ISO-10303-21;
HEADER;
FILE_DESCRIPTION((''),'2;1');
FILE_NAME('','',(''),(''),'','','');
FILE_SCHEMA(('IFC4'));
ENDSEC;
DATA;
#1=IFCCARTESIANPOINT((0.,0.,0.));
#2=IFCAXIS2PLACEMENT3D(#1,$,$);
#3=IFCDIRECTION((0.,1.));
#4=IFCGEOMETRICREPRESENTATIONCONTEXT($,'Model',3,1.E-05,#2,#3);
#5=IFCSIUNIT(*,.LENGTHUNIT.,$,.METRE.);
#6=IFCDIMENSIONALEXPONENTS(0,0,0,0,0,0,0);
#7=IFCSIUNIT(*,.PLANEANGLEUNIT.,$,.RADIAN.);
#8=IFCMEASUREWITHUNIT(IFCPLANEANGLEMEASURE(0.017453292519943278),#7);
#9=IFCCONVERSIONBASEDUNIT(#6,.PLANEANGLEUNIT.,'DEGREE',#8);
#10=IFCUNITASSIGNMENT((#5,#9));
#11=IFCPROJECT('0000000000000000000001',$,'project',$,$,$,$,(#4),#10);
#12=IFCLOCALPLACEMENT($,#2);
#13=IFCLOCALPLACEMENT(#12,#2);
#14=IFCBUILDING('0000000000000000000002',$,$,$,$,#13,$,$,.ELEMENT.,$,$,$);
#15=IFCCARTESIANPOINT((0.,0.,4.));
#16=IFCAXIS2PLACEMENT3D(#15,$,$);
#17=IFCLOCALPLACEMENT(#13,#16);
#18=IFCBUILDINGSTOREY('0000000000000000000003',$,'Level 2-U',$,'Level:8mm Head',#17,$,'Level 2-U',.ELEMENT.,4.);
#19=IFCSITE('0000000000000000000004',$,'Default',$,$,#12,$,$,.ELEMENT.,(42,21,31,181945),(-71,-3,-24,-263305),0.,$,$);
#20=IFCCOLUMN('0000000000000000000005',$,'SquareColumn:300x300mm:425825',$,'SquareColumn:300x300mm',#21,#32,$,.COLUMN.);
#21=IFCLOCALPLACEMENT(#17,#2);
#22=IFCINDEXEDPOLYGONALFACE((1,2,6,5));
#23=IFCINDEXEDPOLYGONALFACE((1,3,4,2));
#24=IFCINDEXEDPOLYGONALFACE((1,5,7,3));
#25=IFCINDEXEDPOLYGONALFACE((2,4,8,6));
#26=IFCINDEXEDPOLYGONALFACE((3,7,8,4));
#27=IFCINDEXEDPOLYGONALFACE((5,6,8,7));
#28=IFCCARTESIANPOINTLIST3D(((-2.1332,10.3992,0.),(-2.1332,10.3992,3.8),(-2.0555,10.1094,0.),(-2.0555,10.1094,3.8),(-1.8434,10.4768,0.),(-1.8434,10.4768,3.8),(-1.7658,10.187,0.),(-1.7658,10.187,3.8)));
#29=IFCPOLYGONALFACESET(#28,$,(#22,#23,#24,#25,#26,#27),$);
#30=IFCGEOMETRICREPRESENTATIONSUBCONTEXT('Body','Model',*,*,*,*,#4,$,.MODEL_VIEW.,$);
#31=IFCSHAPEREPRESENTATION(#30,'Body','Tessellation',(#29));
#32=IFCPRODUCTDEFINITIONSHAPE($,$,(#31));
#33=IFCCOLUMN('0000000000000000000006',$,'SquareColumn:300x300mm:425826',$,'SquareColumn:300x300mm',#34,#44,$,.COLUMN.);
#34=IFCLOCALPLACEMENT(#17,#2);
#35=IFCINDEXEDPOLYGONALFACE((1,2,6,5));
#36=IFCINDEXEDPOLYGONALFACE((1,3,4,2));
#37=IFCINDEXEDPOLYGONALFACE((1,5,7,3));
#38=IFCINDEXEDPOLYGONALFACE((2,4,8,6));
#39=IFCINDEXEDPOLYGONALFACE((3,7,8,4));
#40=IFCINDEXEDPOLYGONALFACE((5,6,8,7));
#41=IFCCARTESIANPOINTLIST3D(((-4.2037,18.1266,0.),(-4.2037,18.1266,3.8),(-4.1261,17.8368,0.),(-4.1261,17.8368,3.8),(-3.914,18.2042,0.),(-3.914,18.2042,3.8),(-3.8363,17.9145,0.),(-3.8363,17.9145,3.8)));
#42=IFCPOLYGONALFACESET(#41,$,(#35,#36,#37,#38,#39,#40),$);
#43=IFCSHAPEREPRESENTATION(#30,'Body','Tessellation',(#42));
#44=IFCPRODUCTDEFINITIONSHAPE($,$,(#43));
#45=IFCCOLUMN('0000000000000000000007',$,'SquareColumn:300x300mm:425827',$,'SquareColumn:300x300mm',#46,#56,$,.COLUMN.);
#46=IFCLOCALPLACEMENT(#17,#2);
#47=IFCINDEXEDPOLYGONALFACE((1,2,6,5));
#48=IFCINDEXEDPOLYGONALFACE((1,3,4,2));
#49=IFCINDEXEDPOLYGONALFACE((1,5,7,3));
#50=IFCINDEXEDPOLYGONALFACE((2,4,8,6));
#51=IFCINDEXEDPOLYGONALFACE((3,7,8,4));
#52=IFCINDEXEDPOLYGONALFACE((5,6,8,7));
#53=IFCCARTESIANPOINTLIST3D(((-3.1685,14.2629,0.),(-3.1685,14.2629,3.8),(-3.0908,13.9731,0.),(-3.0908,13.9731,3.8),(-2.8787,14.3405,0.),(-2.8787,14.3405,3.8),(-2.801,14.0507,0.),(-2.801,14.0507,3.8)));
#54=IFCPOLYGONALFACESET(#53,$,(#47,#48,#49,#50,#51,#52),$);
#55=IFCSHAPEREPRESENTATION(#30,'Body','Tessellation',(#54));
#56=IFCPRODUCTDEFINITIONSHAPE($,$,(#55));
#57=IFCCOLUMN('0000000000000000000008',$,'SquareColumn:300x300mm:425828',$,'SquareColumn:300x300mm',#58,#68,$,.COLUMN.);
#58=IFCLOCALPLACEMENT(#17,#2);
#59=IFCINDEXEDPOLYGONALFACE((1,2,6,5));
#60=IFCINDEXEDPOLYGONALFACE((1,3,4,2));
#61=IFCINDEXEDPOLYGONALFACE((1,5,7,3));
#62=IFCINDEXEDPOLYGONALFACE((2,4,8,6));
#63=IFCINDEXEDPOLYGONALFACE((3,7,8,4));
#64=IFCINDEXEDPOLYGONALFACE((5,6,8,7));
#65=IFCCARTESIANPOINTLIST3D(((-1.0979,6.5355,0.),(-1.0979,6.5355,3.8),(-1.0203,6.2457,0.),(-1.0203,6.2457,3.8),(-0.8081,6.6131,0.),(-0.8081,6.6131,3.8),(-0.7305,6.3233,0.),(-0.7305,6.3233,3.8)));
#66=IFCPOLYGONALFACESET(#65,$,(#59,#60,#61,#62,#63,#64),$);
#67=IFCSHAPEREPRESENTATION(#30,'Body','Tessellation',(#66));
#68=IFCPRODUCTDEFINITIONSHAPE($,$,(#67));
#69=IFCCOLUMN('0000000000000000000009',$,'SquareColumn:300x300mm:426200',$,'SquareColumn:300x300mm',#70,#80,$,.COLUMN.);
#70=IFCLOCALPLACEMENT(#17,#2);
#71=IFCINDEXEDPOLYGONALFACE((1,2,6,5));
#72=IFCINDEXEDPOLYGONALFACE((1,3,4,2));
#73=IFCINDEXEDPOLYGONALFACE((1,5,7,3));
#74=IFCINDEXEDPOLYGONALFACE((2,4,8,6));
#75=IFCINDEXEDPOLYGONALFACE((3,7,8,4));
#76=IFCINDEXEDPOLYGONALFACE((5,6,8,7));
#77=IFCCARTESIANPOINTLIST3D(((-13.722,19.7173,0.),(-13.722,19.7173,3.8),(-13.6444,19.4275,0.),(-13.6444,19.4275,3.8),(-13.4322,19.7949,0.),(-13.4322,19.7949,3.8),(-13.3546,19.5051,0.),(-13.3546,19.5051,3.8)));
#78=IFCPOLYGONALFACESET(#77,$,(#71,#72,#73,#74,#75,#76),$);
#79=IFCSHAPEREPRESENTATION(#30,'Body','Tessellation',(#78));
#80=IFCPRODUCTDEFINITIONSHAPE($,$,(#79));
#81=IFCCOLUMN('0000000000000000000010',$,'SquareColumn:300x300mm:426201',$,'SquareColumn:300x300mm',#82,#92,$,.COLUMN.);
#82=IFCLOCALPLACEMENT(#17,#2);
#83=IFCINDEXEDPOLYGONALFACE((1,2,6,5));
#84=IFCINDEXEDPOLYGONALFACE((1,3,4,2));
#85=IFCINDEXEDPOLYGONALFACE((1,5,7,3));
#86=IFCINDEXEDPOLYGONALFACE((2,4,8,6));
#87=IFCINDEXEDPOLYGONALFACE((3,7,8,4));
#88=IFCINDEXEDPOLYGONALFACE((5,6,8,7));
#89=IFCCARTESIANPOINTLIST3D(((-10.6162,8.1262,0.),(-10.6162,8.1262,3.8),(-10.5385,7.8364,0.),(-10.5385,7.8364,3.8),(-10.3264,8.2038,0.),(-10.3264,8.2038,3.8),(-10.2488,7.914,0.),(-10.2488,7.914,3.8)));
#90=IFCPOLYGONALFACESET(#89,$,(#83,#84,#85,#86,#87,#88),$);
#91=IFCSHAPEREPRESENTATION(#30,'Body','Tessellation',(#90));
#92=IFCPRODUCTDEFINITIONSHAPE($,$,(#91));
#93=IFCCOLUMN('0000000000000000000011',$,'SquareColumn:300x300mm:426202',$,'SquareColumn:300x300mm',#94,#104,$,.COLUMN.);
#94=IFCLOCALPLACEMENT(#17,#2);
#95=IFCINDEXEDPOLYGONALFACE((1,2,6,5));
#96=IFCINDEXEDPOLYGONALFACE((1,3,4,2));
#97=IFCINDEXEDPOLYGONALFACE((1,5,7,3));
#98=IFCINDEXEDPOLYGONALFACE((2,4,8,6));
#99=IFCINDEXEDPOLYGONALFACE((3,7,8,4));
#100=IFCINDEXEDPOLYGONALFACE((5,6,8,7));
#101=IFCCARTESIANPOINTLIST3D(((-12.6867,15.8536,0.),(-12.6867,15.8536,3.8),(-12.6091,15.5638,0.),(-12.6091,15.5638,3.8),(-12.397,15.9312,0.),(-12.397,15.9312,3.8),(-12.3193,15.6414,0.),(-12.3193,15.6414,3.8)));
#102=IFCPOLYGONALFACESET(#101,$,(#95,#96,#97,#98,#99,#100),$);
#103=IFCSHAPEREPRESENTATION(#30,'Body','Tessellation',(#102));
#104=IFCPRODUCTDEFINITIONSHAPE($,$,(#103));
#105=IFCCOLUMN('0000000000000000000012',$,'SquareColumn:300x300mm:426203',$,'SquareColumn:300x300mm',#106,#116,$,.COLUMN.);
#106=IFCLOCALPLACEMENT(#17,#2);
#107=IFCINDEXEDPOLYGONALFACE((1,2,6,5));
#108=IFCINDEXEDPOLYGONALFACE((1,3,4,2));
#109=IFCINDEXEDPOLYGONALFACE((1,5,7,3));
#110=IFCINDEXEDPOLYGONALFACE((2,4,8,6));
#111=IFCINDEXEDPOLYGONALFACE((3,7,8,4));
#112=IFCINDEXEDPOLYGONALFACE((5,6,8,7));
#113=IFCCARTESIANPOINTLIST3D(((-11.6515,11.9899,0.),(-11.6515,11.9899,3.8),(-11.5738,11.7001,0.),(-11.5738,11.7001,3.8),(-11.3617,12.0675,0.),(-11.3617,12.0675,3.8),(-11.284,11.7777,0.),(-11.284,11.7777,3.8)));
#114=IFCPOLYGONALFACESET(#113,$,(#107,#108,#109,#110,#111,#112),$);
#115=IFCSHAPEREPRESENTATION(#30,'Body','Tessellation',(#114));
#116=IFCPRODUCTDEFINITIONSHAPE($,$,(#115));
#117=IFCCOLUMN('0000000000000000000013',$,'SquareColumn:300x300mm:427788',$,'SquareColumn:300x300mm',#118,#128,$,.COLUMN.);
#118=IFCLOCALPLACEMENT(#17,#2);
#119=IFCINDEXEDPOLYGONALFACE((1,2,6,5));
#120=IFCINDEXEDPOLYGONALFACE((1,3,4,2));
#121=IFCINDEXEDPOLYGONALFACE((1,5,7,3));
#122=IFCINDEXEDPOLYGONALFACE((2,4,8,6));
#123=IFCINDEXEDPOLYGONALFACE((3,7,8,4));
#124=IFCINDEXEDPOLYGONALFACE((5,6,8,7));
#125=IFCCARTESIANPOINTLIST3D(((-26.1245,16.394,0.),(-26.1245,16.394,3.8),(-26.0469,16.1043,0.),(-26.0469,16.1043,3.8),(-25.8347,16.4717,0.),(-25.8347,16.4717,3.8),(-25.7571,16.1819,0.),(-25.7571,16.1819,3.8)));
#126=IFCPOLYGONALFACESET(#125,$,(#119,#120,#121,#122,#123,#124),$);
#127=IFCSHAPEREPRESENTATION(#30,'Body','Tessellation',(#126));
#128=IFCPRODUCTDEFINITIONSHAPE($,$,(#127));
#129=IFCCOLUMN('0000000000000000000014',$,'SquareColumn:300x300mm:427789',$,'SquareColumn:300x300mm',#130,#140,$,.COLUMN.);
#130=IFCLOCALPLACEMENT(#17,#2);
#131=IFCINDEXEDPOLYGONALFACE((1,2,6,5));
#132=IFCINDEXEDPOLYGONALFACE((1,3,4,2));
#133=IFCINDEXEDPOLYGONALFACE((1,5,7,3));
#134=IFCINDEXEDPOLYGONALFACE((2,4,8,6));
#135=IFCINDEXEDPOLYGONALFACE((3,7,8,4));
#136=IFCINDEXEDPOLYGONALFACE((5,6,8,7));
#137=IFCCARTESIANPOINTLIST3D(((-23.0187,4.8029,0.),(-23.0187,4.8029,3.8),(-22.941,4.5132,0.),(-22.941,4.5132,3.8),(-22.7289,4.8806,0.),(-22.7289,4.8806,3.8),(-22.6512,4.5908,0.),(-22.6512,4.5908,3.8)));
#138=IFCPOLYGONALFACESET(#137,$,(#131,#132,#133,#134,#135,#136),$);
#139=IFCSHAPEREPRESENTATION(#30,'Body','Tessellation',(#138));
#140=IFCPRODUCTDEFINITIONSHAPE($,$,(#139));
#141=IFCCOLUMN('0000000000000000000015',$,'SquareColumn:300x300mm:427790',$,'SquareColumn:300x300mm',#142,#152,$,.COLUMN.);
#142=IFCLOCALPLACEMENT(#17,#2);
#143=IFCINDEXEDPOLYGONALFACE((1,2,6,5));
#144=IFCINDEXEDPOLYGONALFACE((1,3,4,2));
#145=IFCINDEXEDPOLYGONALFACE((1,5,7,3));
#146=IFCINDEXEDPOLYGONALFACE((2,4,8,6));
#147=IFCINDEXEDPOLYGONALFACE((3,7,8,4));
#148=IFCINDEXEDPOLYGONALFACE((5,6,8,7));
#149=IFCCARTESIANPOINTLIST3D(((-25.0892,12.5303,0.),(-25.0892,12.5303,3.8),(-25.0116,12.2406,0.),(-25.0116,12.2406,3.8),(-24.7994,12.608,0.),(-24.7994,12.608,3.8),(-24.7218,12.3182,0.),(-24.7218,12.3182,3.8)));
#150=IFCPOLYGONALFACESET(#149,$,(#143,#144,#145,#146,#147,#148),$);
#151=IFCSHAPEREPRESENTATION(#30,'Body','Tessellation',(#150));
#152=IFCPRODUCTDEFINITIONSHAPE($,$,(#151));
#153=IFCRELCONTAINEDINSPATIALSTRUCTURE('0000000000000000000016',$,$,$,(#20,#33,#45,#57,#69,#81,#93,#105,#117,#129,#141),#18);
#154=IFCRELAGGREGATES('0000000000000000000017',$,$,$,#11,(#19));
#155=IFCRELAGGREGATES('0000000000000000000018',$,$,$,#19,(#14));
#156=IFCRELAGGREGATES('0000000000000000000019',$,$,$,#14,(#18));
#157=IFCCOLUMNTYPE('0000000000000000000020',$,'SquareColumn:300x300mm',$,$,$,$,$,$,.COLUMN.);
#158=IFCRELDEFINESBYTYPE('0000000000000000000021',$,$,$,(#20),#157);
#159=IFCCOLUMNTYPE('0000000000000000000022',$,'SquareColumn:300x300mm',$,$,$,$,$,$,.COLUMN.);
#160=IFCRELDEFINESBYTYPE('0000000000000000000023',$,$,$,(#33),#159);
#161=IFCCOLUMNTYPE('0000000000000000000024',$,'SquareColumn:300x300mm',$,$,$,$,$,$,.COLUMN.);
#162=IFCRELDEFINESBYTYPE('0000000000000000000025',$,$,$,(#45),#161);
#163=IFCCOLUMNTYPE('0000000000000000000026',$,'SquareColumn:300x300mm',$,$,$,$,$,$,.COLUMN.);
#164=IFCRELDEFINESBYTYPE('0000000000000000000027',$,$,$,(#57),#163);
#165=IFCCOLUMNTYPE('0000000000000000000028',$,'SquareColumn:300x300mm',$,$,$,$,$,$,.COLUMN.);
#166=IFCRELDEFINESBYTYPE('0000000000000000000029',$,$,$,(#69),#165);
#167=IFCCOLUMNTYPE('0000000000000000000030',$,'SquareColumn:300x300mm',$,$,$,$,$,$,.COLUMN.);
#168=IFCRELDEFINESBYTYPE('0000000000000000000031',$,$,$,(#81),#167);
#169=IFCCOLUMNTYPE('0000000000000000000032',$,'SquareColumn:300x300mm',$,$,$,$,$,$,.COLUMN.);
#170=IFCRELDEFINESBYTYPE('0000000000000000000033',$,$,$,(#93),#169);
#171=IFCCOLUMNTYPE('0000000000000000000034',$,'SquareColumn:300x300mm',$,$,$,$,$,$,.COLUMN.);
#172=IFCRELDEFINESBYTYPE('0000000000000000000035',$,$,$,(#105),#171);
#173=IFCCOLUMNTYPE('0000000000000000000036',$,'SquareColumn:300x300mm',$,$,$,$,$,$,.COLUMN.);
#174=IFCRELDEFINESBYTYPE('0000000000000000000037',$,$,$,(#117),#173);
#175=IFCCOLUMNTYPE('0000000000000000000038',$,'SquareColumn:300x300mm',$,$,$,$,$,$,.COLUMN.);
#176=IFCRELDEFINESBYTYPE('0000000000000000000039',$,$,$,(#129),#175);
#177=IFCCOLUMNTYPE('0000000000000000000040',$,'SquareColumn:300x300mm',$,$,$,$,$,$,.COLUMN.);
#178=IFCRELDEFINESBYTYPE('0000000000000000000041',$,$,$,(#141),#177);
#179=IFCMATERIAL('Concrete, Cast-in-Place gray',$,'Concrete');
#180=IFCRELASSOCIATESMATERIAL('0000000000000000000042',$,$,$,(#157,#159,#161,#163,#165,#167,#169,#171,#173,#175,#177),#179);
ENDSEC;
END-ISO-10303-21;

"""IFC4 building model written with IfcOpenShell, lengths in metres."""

from ifc_helpers import new_model, entity, si_unit, converted_unit, direction, frame, frame_2d, origin, origin_2d_with_axis, place, context, subcontext, project, spatial, rectangle, extrude, source, transform, mapped, material, material_profile, profile_set, type_object, type_shapes, element, save


model = new_model("IFC4")

# Units and contexts
model_context = context("Model", 3, precision=1e-05, world=origin(), true_north=direction((0.0, 1.0)))
body_context = subcontext(model_context, "Body", "Model", "MODEL_VIEW")
ifc_project = project(units=[si_unit("LENGTHUNIT", "METRE"), converted_unit("PLANEANGLEUNIT", "DEGREE", entity("IfcPlaneAngleMeasure", 0.017453292519943278), si_unit("PLANEANGLEUNIT", "RADIAN"), dimensions=[0, 0, 0, 0, 0, 0, 0])], contexts=[model_context])

# Site, building, storey
site_placement = place(None, origin())
site = spatial("IfcSite", under=ifc_project, at=site_placement, Name="Default", CompositionType="ELEMENT", RefLatitude=(42, 21, 31, 181945), RefLongitude=(-71, -3, -24, -263305), RefElevation=0.0)
building_placement = place(site_placement, origin())
building = spatial("IfcBuilding", under=site, at=building_placement, CompositionType="ELEMENT")
storey_placement = place(building_placement, frame((0.0, 0.0, 4.0)))
storey = spatial("IfcBuildingStorey", under=building, at=storey_placement, Name="Level 2-U", ObjectType="Level:8mm Head", LongName="Level 2-U", CompositionType="ELEMENT", Elevation=4.0)

# Columns
ifc_material_1 = material(Name="Concrete, Cast-in-Place gray", Category="Concrete")
ifc_material_profile = material_profile(ifc_material_1, rectangle(XDim=0.3, YDim=0.3, at=origin_2d_with_axis()), Name="300x300mm")
ifc_profile_set = profile_set([ifc_material_profile], Name="300x300mm")
column_type_1 = type_object("IfcColumnType", Name="SquareColumn:300x300mm", PredefinedType="COLUMN", material=ifc_profile_set)
shared_shape_1 = source(origin(), body_context, "Body", "SweptSolid", [
    extrude(rectangle(XDim=0.3, YDim=0.3, at=frame_2d((0.0, 0.0), x_axis=(1.0, 0.0))), frame((-1.9495, 10.2931, 4.0), z_axis=(0.0, 0.0, 1.0), x_axis=(-0.258819, 0.965926, 0.0)), (0.0, 0.0, 1.0), 3.8),
])
type_shapes(column_type_1, [shared_shape_1])
column_1_placement = place(storey_placement, frame((0.0, 0.0, -4.0)))
element("IfcColumn", 1, at=column_1_placement, inside=storey, type_object=column_type_1, Name="SquareColumn:300x300mm:425825", ObjectType="SquareColumn:300x300mm", PredefinedType="COLUMN", context=body_context, shape_type="MappedRepresentation", body=[
    mapped(shared_shape_1, transform((0.0, 0.0, 0.0), scale=1.0)),
])
column_type_2 = type_object("IfcColumnType", Name="SquareColumn:300x300mm", PredefinedType="COLUMN", material=ifc_profile_set)
shared_shape_2 = source(origin(), body_context, "Body", "SweptSolid", [
    extrude(rectangle(XDim=0.3, YDim=0.3, at=origin_2d_with_axis()), frame((-4.02, 18.0205, 4.0), z_axis=(0.0, 0.0, 1.0), x_axis=(-0.258819, 0.965926, 0.0)), (0.0, 0.0, 1.0), 3.8),
])
type_shapes(column_type_2, [shared_shape_2])
column_2_placement = place(storey_placement, frame((0.0, 0.0, -4.0)))
element("IfcColumn", 2, at=column_2_placement, inside=storey, type_object=column_type_2, Name="SquareColumn:300x300mm:425826", ObjectType="SquareColumn:300x300mm", PredefinedType="COLUMN", context=body_context, shape_type="MappedRepresentation", body=[
    mapped(shared_shape_2, transform((0.0, 0.0, 0.0), scale=1.0)),
])
column_type_3 = type_object("IfcColumnType", Name="SquareColumn:300x300mm", PredefinedType="COLUMN", material=ifc_profile_set)
shared_shape_3 = source(origin(), body_context, "Body", "SweptSolid", [
    extrude(rectangle(XDim=0.3, YDim=0.3, at=origin_2d_with_axis()), frame((-2.9847, 14.1568, 4.0), z_axis=(0.0, 0.0, 1.0), x_axis=(-0.258819, 0.965926, 0.0)), (0.0, 0.0, 1.0), 3.8),
])
type_shapes(column_type_3, [shared_shape_3])
column_3_placement = place(storey_placement, frame((0.0, 0.0, -4.0)))
element("IfcColumn", 3, at=column_3_placement, inside=storey, type_object=column_type_3, Name="SquareColumn:300x300mm:425827", ObjectType="SquareColumn:300x300mm", PredefinedType="COLUMN", context=body_context, shape_type="MappedRepresentation", body=[
    mapped(shared_shape_3, transform((0.0, 0.0, 0.0), scale=1.0)),
])
column_type_4 = type_object("IfcColumnType", Name="SquareColumn:300x300mm", PredefinedType="COLUMN", material=ifc_profile_set)
shared_shape_4 = source(origin(), body_context, "Body", "SweptSolid", [
    extrude(rectangle(XDim=0.3, YDim=0.3, at=frame_2d((0.0, 0.0), x_axis=(1.0, 0.0))), frame((-0.9142, 6.4294, 4.0), z_axis=(0.0, 0.0, 1.0), x_axis=(-0.258819, 0.965926, 0.0)), (0.0, 0.0, 1.0), 3.8),
])
type_shapes(column_type_4, [shared_shape_4])
column_4_placement = place(storey_placement, frame((0.0, 0.0, -4.0)))
element("IfcColumn", 4, at=column_4_placement, inside=storey, type_object=column_type_4, Name="SquareColumn:300x300mm:425828", ObjectType="SquareColumn:300x300mm", PredefinedType="COLUMN", context=body_context, shape_type="MappedRepresentation", body=[
    mapped(shared_shape_4, transform((0.0, 0.0, 0.0), scale=1.0)),
])
column_type_5 = type_object("IfcColumnType", Name="SquareColumn:300x300mm", PredefinedType="COLUMN", material=ifc_profile_set)
shared_shape_5 = source(origin(), body_context, "Body", "SweptSolid", [
    extrude(rectangle(XDim=0.3, YDim=0.3, at=origin_2d_with_axis()), frame((-13.5383, 19.6112, 4.0), z_axis=(0.0, 0.0, 1.0), x_axis=(-0.258819, 0.965926, 0.0)), (0.0, 0.0, 1.0), 3.8),
])
type_shapes(column_type_5, [shared_shape_5])
column_5_placement = place(storey_placement, frame((0.0, 0.0, -4.0)))
element("IfcColumn", 5, at=column_5_placement, inside=storey, type_object=column_type_5, Name="SquareColumn:300x300mm:426200", ObjectType="SquareColumn:300x300mm", PredefinedType="COLUMN", context=body_context, shape_type="MappedRepresentation", body=[
    mapped(shared_shape_5, transform((0.0, 0.0, 0.0), scale=1.0)),
])
column_type_6 = type_object("IfcColumnType", Name="SquareColumn:300x300mm", PredefinedType="COLUMN", material=ifc_profile_set)
shared_shape_6 = source(origin(), body_context, "Body", "SweptSolid", [
    extrude(rectangle(XDim=0.3, YDim=0.3, at=origin_2d_with_axis()), frame((-10.4325, 8.0201, 4.0), z_axis=(0.0, 0.0, 1.0), x_axis=(-0.258819, 0.965926, 0.0)), (0.0, 0.0, 1.0), 3.8),
])
type_shapes(column_type_6, [shared_shape_6])
column_6_placement = place(storey_placement, frame((0.0, 0.0, -4.0)))
element("IfcColumn", 6, at=column_6_placement, inside=storey, type_object=column_type_6, Name="SquareColumn:300x300mm:426201", ObjectType="SquareColumn:300x300mm", PredefinedType="COLUMN", context=body_context, shape_type="MappedRepresentation", body=[
    mapped(shared_shape_6, transform((0.0, 0.0, 0.0), scale=1.0)),
])
column_type_7 = type_object("IfcColumnType", Name="SquareColumn:300x300mm", PredefinedType="COLUMN", material=ifc_profile_set)
shared_shape_7 = source(origin(), body_context, "Body", "SweptSolid", [
    extrude(rectangle(XDim=0.3, YDim=0.3, at=origin_2d_with_axis()), frame((-12.503, 15.7475, 4.0), z_axis=(0.0, 0.0, 1.0), x_axis=(-0.258819, 0.965926, 0.0)), (0.0, 0.0, 1.0), 3.8),
])
type_shapes(column_type_7, [shared_shape_7])
column_7_placement = place(storey_placement, frame((0.0, 0.0, -4.0)))
element("IfcColumn", 7, at=column_7_placement, inside=storey, type_object=column_type_7, Name="SquareColumn:300x300mm:426202", ObjectType="SquareColumn:300x300mm", PredefinedType="COLUMN", context=body_context, shape_type="MappedRepresentation", body=[
    mapped(shared_shape_7, transform((0.0, 0.0, 0.0), scale=1.0)),
])
column_type_8 = type_object("IfcColumnType", Name="SquareColumn:300x300mm", PredefinedType="COLUMN", material=ifc_profile_set)
shared_shape_8 = source(origin(), body_context, "Body", "SweptSolid", [
    extrude(rectangle(XDim=0.3, YDim=0.3, at=origin_2d_with_axis()), frame((-11.4677, 11.8838, 4.0), z_axis=(0.0, 0.0, 1.0), x_axis=(-0.258819, 0.965926, 0.0)), (0.0, 0.0, 1.0), 3.8),
])
type_shapes(column_type_8, [shared_shape_8])
column_8_placement = place(storey_placement, frame((0.0, 0.0, -4.0)))
element("IfcColumn", 8, at=column_8_placement, inside=storey, type_object=column_type_8, Name="SquareColumn:300x300mm:426203", ObjectType="SquareColumn:300x300mm", PredefinedType="COLUMN", context=body_context, shape_type="MappedRepresentation", body=[
    mapped(shared_shape_8, transform((0.0, 0.0, 0.0), scale=1.0)),
])
column_type_9 = type_object("IfcColumnType", Name="SquareColumn:300x300mm", PredefinedType="COLUMN", material=ifc_profile_set)
shared_shape_9 = source(origin(), body_context, "Body", "SweptSolid", [
    extrude(rectangle(XDim=0.3, YDim=0.3, at=origin_2d_with_axis()), frame((-25.9408, 16.288, 4.0), z_axis=(0.0, 0.0, 1.0), x_axis=(-0.258819, 0.965926, 0.0)), (0.0, 0.0, 1.0), 3.8),
])
type_shapes(column_type_9, [shared_shape_9])
column_9_placement = place(storey_placement, frame((0.0, 0.0, -4.0)))
element("IfcColumn", 9, at=column_9_placement, inside=storey, type_object=column_type_9, Name="SquareColumn:300x300mm:427788", ObjectType="SquareColumn:300x300mm", PredefinedType="COLUMN", context=body_context, shape_type="MappedRepresentation", body=[
    mapped(shared_shape_9, transform((0.0, 0.0, 0.0), scale=1.0)),
])
column_type_10 = type_object("IfcColumnType", Name="SquareColumn:300x300mm", PredefinedType="COLUMN", material=ifc_profile_set)
shared_shape_10 = source(origin(), body_context, "Body", "SweptSolid", [
    extrude(rectangle(XDim=0.3, YDim=0.3, at=origin_2d_with_axis()), frame((-22.835, 4.6969, 4.0), z_axis=(0.0, 0.0, 1.0), x_axis=(-0.258819, 0.965926, 0.0)), (0.0, 0.0, 1.0), 3.8),
])
type_shapes(column_type_10, [shared_shape_10])
column_10_placement = place(storey_placement, frame((0.0, 0.0, -4.0)))
element("IfcColumn", 10, at=column_10_placement, inside=storey, type_object=column_type_10, Name="SquareColumn:300x300mm:427789", ObjectType="SquareColumn:300x300mm", PredefinedType="COLUMN", context=body_context, shape_type="MappedRepresentation", body=[
    mapped(shared_shape_10, transform((0.0, 0.0, 0.0), scale=1.0)),
])
column_type_11 = type_object("IfcColumnType", Name="SquareColumn:300x300mm", PredefinedType="COLUMN", material=ifc_profile_set)
shared_shape_11 = source(origin(), body_context, "Body", "SweptSolid", [
    extrude(rectangle(XDim=0.3, YDim=0.3, at=origin_2d_with_axis()), frame((-24.9055, 12.4243, 4.0), z_axis=(0.0, 0.0, 1.0), x_axis=(-0.258819, 0.965926, 0.0)), (0.0, 0.0, 1.0), 3.8),
])
type_shapes(column_type_11, [shared_shape_11])
column_11_placement = place(storey_placement, frame((0.0, 0.0, -4.0)))
element("IfcColumn", 11, at=column_11_placement, inside=storey, type_object=column_type_11, Name="SquareColumn:300x300mm:427790", ObjectType="SquareColumn:300x300mm", PredefinedType="COLUMN", context=body_context, shape_type="MappedRepresentation", body=[
    mapped(shared_shape_11, transform((0.0, 0.0, 0.0), scale=1.0)),
])

save(model, "model.ifc")
